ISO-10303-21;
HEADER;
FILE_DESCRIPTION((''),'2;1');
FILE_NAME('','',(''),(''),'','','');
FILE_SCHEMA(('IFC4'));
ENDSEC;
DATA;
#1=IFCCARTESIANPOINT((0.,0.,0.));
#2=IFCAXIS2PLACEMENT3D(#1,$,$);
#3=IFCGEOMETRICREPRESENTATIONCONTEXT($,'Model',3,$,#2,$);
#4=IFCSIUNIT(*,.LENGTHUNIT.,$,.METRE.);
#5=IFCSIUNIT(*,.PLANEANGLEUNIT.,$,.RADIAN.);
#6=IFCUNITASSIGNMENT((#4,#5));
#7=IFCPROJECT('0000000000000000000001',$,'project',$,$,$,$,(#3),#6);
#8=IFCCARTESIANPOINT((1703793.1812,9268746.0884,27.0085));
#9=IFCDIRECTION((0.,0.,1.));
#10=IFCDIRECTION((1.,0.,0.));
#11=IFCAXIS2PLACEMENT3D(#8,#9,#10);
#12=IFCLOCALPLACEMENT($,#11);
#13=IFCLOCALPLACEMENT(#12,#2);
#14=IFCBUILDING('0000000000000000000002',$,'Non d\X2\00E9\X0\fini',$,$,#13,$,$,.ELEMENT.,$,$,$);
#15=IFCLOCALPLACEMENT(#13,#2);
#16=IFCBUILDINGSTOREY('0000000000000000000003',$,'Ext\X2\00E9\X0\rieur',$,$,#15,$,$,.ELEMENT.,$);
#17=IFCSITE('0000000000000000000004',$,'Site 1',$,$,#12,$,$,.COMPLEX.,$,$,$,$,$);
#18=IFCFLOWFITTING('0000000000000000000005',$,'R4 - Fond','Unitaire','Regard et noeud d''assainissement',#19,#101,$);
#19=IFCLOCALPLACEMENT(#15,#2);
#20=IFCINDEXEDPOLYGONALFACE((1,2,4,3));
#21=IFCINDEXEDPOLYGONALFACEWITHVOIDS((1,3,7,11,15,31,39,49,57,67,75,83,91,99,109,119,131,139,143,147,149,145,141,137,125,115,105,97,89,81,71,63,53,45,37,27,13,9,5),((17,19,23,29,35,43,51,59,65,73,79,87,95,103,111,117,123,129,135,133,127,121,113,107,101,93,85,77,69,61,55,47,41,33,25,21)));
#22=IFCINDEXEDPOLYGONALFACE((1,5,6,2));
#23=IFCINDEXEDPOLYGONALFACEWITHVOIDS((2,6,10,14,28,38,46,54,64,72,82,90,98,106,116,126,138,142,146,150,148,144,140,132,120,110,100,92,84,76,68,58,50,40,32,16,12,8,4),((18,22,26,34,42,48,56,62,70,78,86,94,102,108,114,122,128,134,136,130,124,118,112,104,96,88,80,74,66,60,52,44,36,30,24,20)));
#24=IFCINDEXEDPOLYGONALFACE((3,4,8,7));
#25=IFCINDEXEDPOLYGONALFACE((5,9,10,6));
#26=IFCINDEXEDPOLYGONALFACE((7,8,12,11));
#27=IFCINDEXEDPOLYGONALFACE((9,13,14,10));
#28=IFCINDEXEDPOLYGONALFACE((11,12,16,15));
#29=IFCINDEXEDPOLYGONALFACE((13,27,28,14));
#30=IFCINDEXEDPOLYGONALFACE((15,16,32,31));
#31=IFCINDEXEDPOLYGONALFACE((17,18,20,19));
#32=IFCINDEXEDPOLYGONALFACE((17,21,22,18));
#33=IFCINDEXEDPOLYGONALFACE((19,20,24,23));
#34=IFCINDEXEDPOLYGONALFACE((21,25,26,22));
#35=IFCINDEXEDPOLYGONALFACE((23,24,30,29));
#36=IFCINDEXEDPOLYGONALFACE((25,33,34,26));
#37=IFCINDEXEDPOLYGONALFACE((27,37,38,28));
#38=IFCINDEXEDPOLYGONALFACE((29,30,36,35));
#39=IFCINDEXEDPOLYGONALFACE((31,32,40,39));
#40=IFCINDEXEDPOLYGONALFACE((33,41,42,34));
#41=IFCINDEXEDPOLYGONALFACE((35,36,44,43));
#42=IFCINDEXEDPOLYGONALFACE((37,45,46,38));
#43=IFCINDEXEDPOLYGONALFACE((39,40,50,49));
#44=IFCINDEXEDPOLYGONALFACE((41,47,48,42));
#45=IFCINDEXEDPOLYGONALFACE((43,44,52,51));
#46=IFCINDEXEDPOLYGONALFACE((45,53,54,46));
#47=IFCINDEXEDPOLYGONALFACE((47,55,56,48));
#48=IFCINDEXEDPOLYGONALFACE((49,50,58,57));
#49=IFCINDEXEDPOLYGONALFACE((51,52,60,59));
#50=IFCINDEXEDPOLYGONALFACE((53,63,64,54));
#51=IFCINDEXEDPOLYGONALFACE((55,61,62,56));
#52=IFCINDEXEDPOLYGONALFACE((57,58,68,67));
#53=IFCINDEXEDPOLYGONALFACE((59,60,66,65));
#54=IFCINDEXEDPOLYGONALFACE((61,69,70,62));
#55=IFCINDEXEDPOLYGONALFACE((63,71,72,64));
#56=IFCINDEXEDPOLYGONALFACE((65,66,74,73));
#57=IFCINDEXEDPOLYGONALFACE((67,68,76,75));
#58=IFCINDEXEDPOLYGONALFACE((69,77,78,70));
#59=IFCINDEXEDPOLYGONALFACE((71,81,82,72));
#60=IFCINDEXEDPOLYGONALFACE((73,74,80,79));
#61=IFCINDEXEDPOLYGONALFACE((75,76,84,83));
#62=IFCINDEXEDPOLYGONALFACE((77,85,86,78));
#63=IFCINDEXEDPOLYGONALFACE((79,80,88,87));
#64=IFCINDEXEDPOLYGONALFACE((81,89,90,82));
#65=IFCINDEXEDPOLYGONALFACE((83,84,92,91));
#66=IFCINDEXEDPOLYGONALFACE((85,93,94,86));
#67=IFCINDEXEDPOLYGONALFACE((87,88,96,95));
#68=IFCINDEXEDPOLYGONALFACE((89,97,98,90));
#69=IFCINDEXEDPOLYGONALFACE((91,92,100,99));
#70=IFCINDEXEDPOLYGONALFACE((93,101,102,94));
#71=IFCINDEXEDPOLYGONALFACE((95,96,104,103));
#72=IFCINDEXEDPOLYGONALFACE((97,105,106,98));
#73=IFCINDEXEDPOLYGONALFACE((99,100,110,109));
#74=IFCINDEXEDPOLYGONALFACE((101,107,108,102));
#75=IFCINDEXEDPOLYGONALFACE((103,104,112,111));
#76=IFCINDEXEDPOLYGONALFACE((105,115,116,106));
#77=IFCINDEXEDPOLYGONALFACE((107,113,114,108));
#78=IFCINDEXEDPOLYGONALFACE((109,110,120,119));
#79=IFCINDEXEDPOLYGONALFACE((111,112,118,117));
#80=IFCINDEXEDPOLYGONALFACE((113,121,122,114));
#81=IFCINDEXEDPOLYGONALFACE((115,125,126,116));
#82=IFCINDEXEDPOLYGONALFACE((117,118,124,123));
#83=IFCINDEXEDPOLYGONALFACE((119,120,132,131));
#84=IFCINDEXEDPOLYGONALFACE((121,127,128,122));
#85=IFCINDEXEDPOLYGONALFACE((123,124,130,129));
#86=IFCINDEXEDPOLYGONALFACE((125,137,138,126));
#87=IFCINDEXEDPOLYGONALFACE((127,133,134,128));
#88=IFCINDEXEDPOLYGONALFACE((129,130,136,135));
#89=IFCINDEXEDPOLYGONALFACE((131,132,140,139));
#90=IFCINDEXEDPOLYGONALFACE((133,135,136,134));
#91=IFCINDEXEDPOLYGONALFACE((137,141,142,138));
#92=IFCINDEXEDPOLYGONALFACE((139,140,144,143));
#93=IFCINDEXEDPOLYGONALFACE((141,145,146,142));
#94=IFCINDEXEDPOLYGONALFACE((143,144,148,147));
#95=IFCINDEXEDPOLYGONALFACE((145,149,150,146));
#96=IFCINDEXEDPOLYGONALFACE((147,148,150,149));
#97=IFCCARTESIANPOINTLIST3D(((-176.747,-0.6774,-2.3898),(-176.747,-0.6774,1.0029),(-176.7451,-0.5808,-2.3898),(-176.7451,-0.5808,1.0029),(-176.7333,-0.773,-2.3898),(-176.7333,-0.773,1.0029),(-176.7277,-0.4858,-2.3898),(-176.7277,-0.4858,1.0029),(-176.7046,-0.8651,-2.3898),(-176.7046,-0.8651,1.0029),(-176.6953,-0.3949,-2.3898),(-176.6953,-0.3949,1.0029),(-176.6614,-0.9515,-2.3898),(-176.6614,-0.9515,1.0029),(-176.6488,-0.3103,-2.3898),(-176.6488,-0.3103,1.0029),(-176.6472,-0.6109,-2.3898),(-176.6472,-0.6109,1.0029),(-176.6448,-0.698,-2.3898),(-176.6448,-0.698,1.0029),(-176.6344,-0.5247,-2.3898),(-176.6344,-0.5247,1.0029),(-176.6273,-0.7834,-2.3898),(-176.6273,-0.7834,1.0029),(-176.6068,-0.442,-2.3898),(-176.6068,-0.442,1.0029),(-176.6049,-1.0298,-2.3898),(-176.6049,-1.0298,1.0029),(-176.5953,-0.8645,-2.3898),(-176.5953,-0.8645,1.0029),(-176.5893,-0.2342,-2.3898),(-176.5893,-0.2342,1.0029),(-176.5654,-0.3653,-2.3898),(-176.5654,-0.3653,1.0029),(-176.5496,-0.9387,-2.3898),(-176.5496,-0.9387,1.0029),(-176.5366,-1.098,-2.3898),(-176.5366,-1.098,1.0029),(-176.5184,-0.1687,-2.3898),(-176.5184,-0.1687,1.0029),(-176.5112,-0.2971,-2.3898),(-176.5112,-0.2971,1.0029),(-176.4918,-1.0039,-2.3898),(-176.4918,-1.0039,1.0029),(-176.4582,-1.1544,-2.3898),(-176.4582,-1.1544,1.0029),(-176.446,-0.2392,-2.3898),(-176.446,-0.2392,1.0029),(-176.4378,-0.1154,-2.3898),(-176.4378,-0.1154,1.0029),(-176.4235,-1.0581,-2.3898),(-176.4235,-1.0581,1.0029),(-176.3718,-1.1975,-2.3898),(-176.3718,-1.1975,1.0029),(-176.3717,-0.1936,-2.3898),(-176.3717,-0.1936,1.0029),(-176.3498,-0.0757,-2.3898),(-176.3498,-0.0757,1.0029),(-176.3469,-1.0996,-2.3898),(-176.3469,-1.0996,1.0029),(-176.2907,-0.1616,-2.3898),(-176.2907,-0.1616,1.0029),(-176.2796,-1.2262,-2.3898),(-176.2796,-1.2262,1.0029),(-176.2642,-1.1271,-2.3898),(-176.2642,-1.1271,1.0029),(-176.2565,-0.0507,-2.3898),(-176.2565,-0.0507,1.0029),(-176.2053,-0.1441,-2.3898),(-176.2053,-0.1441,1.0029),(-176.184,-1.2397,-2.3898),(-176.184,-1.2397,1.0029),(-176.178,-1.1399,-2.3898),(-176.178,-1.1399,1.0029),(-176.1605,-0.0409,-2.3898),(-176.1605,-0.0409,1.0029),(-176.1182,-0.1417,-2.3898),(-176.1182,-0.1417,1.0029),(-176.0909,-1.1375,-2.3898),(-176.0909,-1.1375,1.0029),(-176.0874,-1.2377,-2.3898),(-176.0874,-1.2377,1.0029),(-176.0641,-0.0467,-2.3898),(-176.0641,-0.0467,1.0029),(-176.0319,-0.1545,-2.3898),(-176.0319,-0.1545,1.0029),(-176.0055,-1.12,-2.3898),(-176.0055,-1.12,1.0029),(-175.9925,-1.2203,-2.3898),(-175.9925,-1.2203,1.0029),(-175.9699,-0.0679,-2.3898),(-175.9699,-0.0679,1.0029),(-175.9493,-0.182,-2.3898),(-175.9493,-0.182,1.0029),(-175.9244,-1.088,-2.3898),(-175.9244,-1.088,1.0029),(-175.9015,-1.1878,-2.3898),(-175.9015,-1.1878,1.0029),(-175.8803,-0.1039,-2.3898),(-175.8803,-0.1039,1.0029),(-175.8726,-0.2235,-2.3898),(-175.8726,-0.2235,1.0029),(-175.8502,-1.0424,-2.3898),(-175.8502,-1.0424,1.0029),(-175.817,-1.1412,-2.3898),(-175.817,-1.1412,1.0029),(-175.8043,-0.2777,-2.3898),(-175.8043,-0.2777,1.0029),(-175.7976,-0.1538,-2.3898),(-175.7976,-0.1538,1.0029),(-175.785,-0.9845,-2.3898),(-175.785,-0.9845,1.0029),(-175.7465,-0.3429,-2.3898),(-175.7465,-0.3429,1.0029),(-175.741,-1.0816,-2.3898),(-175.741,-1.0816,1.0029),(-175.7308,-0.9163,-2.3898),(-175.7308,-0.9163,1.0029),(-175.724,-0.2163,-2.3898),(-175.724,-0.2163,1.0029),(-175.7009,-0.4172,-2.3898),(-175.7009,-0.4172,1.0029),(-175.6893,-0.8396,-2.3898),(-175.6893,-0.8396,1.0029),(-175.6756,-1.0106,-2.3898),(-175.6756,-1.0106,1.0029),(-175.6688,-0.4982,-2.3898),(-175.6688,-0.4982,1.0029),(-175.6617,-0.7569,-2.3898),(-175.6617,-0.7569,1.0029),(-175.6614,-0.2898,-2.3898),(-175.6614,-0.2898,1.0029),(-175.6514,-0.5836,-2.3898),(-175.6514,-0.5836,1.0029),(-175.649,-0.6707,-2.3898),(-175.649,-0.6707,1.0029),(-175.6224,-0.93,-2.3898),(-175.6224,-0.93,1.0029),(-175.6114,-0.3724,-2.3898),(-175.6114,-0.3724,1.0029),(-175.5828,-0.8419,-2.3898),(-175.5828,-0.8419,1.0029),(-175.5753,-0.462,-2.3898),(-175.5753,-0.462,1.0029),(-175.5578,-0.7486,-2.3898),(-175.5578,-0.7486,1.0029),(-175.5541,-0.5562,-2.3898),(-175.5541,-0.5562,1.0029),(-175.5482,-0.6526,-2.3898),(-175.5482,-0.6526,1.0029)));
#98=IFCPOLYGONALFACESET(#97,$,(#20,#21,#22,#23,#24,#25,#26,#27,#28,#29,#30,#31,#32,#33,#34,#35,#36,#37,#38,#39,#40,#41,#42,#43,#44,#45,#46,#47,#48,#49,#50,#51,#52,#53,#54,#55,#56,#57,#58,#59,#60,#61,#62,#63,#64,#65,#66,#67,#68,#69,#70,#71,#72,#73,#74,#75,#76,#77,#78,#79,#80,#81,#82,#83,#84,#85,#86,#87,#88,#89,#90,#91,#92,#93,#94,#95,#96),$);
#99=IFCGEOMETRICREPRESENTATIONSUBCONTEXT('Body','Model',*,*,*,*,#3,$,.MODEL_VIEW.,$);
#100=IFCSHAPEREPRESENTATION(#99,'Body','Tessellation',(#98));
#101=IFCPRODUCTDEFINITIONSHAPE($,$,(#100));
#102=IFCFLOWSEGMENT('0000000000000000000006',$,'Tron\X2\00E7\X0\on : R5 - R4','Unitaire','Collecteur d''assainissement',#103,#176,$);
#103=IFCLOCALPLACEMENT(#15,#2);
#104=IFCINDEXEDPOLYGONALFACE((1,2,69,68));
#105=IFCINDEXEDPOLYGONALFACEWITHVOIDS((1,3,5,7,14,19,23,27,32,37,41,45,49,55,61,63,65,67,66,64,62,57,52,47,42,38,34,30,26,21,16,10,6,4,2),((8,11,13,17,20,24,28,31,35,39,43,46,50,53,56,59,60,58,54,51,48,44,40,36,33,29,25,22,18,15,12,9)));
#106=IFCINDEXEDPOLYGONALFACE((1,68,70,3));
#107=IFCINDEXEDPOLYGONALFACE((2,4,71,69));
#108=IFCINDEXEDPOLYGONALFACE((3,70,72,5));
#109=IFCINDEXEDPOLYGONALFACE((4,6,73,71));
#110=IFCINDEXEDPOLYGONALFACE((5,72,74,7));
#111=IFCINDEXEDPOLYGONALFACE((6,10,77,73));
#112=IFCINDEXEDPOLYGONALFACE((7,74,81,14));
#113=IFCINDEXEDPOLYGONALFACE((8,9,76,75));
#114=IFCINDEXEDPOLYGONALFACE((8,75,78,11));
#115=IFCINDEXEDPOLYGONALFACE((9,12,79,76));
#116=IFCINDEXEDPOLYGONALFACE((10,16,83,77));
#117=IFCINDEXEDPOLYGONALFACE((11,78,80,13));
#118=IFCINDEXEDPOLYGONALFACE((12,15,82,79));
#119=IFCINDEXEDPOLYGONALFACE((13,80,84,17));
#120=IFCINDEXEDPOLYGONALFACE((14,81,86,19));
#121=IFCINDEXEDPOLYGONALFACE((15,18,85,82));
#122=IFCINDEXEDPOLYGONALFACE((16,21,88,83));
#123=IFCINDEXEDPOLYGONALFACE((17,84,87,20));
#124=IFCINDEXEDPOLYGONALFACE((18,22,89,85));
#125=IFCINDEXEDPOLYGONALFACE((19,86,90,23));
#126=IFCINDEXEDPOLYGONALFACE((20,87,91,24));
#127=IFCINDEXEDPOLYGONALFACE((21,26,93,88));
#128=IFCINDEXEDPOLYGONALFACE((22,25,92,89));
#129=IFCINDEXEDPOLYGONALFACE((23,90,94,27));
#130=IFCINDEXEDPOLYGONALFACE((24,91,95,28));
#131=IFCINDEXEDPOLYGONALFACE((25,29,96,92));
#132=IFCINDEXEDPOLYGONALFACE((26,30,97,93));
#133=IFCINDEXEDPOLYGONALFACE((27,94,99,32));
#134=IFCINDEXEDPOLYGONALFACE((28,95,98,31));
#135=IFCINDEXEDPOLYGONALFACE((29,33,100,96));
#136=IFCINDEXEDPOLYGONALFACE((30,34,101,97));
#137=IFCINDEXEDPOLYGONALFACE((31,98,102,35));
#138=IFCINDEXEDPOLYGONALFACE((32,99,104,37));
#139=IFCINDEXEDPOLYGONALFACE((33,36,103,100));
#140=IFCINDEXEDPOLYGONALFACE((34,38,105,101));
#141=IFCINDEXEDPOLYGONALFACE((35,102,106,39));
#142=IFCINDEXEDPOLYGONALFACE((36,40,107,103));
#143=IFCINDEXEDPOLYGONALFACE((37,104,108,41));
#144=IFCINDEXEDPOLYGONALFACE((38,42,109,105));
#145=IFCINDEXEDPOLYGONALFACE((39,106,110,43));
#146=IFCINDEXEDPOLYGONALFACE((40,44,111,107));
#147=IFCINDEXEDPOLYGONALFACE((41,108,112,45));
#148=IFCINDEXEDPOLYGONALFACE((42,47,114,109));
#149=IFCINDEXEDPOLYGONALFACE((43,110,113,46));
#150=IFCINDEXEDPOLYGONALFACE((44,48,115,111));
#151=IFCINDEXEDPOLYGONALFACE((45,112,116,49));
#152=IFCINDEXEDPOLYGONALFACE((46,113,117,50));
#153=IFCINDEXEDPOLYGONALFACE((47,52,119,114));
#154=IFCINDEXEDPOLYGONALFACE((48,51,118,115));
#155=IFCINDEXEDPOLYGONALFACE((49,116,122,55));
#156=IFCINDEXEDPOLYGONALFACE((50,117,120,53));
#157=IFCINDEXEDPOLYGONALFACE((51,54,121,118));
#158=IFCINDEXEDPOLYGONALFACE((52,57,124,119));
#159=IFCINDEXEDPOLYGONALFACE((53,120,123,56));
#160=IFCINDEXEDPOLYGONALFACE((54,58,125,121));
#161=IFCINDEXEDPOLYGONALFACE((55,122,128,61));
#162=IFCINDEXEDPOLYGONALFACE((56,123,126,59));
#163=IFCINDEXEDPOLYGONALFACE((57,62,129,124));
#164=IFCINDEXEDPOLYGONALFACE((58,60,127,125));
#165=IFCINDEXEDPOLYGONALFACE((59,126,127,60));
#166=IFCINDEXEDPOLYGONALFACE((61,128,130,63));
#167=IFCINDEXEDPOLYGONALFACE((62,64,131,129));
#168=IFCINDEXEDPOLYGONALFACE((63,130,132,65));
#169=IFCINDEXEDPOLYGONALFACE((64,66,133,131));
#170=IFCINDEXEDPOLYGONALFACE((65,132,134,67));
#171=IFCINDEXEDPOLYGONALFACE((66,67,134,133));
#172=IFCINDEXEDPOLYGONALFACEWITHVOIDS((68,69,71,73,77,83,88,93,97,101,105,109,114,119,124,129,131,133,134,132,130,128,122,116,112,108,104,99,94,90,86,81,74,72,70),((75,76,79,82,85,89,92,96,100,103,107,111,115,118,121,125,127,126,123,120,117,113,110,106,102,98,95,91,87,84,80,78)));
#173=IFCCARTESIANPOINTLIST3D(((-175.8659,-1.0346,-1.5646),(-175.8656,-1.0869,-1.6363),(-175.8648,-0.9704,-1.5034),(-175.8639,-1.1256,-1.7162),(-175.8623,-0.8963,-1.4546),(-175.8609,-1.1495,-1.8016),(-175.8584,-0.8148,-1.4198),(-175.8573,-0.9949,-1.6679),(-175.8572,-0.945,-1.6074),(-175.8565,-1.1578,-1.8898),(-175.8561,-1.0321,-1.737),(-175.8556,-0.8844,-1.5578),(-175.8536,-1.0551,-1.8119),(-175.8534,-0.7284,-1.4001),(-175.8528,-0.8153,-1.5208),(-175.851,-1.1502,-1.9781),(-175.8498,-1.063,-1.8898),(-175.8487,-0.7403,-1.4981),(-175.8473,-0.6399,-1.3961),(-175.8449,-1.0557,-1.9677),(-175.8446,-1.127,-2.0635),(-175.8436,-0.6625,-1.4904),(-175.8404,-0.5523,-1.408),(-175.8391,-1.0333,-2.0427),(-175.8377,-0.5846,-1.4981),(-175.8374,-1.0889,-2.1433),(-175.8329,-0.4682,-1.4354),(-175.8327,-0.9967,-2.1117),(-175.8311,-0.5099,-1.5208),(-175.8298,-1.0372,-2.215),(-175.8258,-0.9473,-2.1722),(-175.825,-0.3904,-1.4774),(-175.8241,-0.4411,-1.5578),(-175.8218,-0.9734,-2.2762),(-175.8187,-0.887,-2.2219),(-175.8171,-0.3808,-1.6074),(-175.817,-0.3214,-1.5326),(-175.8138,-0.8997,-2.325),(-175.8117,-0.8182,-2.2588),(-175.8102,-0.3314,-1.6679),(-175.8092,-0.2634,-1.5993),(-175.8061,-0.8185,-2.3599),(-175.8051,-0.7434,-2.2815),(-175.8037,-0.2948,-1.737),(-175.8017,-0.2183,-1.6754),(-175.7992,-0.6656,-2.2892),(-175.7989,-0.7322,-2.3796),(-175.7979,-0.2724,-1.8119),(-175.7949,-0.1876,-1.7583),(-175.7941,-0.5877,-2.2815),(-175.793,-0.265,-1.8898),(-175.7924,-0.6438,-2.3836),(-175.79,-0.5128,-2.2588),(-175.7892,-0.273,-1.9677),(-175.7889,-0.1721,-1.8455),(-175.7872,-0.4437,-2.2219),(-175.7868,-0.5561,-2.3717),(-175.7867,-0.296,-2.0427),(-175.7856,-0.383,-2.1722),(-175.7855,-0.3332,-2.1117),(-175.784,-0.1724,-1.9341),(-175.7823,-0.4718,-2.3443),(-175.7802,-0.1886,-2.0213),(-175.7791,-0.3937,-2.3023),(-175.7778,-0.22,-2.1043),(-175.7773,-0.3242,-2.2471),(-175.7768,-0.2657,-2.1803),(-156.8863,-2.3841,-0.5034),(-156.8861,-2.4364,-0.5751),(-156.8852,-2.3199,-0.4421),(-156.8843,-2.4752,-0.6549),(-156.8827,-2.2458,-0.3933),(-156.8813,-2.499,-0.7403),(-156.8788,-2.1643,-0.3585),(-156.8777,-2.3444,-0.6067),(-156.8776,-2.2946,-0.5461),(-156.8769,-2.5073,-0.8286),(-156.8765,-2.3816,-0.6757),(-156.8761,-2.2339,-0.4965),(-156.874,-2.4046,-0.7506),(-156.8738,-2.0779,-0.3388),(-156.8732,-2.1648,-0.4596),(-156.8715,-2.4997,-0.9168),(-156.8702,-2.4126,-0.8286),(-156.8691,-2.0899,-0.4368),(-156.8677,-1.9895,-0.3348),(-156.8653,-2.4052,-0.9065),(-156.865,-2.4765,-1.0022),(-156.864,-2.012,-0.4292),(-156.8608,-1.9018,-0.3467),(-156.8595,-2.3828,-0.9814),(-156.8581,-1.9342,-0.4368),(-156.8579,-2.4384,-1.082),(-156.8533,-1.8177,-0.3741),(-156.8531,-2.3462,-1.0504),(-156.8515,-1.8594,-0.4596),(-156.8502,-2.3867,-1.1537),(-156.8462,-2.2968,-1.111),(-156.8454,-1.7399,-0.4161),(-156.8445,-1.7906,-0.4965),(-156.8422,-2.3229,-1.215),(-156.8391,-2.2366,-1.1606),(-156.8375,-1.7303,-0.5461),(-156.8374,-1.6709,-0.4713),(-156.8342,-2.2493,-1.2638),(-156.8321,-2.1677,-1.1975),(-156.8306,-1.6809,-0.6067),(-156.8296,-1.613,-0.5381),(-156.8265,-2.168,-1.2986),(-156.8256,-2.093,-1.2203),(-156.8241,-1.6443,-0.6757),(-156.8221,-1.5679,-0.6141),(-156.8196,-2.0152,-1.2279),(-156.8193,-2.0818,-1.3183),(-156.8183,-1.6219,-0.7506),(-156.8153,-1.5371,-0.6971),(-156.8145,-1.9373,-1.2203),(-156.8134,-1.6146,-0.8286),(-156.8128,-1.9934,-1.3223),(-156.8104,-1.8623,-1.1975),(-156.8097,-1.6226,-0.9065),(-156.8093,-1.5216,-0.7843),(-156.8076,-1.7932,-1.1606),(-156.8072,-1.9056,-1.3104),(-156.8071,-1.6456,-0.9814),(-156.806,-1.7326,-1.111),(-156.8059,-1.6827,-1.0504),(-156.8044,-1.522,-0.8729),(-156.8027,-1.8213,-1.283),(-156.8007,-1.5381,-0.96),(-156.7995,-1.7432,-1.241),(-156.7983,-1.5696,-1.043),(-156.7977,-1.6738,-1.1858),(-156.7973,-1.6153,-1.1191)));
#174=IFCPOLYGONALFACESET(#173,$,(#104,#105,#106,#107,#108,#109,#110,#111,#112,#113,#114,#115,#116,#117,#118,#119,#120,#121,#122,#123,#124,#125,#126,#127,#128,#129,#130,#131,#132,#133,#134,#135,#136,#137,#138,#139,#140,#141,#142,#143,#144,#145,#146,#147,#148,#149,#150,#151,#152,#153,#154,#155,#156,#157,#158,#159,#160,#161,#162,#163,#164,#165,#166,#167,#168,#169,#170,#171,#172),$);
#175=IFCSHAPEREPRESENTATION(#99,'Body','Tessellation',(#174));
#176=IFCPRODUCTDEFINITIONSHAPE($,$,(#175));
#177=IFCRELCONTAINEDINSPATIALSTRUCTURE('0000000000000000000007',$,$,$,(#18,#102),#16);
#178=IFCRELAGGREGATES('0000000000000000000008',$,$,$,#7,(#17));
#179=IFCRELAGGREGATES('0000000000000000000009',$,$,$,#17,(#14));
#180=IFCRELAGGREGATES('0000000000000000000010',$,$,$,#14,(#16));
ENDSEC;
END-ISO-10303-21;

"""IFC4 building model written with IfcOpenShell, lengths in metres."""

from ifc_helpers import new_model, si_unit, frame, origin, origin_2d, place, context, subcontext, project, spatial, hollow_circle, extrude, element, save


model = new_model("IFC4")

# Units and contexts
model_context = context("Model", 3, world=origin())
body_context = subcontext(model_context, "Body", "Model", "MODEL_VIEW")
ifc_project = project(units=[si_unit("LENGTHUNIT", "METRE"), si_unit("PLANEANGLEUNIT", "RADIAN")], contexts=[model_context])

# Site, building, storey
site_placement = place(None, frame((1703793.1812, 9268746.0884, 27.0085), z_axis=(0.0, 0.0, 1.0), x_axis=(1.0, 0.0, 0.0)))
site = spatial("IfcSite", under=ifc_project, at=site_placement, Name="Site 1", CompositionType="COMPLEX")
building_placement = place(site_placement, origin())
building = spatial("IfcBuilding", under=site, at=building_placement, Name="Non défini", CompositionType="ELEMENT")
storey_placement = place(building_placement, origin())
storey = spatial("IfcBuildingStorey", under=building, at=storey_placement, Name="Extérieur", CompositionType="ELEMENT")

# Flow fitting
flow_fitting_1_placement = place(storey_placement, origin())
element("IfcFlowFitting", 1, at=flow_fitting_1_placement, inside=storey, Name="R4 - Fond", Description="Unitaire", ObjectType="Regard et noeud d'assainissement", context=body_context, shape_type="SweptSolid", body=[
    extrude(hollow_circle(Radius=0.6, WallThickness=0.1, at=origin_2d()), frame((-176.1481, -0.6408, -2.3898), z_axis=(0.0, 0.0, 1.0), x_axis=(0.89439, 0.447288, 0.0)), (0.0, 0.0, 1.0), 3.3927),
])

# Flow segment
flow_segment_1_placement = place(storey_placement, origin())
element("IfcFlowSegment", 2, at=flow_segment_1_placement, inside=storey, Name="Tronçon : R5 - R4", Description="Unitaire", ObjectType="Collecteur d'assainissement", context=body_context, shape_type="SweptSolid", body=[
    extrude(hollow_circle(Radius=0.495, WallThickness=0.095, at=origin_2d()), frame((-156.8418, -2.0136, -0.8286), z_axis=(-0.995934, 0.070815, -0.055689), x_axis=(-0.070926, -0.997482, 0.0)), (0.0, 0.0, 1.0), 19.0571),
])

save(model, "model.ifc")
